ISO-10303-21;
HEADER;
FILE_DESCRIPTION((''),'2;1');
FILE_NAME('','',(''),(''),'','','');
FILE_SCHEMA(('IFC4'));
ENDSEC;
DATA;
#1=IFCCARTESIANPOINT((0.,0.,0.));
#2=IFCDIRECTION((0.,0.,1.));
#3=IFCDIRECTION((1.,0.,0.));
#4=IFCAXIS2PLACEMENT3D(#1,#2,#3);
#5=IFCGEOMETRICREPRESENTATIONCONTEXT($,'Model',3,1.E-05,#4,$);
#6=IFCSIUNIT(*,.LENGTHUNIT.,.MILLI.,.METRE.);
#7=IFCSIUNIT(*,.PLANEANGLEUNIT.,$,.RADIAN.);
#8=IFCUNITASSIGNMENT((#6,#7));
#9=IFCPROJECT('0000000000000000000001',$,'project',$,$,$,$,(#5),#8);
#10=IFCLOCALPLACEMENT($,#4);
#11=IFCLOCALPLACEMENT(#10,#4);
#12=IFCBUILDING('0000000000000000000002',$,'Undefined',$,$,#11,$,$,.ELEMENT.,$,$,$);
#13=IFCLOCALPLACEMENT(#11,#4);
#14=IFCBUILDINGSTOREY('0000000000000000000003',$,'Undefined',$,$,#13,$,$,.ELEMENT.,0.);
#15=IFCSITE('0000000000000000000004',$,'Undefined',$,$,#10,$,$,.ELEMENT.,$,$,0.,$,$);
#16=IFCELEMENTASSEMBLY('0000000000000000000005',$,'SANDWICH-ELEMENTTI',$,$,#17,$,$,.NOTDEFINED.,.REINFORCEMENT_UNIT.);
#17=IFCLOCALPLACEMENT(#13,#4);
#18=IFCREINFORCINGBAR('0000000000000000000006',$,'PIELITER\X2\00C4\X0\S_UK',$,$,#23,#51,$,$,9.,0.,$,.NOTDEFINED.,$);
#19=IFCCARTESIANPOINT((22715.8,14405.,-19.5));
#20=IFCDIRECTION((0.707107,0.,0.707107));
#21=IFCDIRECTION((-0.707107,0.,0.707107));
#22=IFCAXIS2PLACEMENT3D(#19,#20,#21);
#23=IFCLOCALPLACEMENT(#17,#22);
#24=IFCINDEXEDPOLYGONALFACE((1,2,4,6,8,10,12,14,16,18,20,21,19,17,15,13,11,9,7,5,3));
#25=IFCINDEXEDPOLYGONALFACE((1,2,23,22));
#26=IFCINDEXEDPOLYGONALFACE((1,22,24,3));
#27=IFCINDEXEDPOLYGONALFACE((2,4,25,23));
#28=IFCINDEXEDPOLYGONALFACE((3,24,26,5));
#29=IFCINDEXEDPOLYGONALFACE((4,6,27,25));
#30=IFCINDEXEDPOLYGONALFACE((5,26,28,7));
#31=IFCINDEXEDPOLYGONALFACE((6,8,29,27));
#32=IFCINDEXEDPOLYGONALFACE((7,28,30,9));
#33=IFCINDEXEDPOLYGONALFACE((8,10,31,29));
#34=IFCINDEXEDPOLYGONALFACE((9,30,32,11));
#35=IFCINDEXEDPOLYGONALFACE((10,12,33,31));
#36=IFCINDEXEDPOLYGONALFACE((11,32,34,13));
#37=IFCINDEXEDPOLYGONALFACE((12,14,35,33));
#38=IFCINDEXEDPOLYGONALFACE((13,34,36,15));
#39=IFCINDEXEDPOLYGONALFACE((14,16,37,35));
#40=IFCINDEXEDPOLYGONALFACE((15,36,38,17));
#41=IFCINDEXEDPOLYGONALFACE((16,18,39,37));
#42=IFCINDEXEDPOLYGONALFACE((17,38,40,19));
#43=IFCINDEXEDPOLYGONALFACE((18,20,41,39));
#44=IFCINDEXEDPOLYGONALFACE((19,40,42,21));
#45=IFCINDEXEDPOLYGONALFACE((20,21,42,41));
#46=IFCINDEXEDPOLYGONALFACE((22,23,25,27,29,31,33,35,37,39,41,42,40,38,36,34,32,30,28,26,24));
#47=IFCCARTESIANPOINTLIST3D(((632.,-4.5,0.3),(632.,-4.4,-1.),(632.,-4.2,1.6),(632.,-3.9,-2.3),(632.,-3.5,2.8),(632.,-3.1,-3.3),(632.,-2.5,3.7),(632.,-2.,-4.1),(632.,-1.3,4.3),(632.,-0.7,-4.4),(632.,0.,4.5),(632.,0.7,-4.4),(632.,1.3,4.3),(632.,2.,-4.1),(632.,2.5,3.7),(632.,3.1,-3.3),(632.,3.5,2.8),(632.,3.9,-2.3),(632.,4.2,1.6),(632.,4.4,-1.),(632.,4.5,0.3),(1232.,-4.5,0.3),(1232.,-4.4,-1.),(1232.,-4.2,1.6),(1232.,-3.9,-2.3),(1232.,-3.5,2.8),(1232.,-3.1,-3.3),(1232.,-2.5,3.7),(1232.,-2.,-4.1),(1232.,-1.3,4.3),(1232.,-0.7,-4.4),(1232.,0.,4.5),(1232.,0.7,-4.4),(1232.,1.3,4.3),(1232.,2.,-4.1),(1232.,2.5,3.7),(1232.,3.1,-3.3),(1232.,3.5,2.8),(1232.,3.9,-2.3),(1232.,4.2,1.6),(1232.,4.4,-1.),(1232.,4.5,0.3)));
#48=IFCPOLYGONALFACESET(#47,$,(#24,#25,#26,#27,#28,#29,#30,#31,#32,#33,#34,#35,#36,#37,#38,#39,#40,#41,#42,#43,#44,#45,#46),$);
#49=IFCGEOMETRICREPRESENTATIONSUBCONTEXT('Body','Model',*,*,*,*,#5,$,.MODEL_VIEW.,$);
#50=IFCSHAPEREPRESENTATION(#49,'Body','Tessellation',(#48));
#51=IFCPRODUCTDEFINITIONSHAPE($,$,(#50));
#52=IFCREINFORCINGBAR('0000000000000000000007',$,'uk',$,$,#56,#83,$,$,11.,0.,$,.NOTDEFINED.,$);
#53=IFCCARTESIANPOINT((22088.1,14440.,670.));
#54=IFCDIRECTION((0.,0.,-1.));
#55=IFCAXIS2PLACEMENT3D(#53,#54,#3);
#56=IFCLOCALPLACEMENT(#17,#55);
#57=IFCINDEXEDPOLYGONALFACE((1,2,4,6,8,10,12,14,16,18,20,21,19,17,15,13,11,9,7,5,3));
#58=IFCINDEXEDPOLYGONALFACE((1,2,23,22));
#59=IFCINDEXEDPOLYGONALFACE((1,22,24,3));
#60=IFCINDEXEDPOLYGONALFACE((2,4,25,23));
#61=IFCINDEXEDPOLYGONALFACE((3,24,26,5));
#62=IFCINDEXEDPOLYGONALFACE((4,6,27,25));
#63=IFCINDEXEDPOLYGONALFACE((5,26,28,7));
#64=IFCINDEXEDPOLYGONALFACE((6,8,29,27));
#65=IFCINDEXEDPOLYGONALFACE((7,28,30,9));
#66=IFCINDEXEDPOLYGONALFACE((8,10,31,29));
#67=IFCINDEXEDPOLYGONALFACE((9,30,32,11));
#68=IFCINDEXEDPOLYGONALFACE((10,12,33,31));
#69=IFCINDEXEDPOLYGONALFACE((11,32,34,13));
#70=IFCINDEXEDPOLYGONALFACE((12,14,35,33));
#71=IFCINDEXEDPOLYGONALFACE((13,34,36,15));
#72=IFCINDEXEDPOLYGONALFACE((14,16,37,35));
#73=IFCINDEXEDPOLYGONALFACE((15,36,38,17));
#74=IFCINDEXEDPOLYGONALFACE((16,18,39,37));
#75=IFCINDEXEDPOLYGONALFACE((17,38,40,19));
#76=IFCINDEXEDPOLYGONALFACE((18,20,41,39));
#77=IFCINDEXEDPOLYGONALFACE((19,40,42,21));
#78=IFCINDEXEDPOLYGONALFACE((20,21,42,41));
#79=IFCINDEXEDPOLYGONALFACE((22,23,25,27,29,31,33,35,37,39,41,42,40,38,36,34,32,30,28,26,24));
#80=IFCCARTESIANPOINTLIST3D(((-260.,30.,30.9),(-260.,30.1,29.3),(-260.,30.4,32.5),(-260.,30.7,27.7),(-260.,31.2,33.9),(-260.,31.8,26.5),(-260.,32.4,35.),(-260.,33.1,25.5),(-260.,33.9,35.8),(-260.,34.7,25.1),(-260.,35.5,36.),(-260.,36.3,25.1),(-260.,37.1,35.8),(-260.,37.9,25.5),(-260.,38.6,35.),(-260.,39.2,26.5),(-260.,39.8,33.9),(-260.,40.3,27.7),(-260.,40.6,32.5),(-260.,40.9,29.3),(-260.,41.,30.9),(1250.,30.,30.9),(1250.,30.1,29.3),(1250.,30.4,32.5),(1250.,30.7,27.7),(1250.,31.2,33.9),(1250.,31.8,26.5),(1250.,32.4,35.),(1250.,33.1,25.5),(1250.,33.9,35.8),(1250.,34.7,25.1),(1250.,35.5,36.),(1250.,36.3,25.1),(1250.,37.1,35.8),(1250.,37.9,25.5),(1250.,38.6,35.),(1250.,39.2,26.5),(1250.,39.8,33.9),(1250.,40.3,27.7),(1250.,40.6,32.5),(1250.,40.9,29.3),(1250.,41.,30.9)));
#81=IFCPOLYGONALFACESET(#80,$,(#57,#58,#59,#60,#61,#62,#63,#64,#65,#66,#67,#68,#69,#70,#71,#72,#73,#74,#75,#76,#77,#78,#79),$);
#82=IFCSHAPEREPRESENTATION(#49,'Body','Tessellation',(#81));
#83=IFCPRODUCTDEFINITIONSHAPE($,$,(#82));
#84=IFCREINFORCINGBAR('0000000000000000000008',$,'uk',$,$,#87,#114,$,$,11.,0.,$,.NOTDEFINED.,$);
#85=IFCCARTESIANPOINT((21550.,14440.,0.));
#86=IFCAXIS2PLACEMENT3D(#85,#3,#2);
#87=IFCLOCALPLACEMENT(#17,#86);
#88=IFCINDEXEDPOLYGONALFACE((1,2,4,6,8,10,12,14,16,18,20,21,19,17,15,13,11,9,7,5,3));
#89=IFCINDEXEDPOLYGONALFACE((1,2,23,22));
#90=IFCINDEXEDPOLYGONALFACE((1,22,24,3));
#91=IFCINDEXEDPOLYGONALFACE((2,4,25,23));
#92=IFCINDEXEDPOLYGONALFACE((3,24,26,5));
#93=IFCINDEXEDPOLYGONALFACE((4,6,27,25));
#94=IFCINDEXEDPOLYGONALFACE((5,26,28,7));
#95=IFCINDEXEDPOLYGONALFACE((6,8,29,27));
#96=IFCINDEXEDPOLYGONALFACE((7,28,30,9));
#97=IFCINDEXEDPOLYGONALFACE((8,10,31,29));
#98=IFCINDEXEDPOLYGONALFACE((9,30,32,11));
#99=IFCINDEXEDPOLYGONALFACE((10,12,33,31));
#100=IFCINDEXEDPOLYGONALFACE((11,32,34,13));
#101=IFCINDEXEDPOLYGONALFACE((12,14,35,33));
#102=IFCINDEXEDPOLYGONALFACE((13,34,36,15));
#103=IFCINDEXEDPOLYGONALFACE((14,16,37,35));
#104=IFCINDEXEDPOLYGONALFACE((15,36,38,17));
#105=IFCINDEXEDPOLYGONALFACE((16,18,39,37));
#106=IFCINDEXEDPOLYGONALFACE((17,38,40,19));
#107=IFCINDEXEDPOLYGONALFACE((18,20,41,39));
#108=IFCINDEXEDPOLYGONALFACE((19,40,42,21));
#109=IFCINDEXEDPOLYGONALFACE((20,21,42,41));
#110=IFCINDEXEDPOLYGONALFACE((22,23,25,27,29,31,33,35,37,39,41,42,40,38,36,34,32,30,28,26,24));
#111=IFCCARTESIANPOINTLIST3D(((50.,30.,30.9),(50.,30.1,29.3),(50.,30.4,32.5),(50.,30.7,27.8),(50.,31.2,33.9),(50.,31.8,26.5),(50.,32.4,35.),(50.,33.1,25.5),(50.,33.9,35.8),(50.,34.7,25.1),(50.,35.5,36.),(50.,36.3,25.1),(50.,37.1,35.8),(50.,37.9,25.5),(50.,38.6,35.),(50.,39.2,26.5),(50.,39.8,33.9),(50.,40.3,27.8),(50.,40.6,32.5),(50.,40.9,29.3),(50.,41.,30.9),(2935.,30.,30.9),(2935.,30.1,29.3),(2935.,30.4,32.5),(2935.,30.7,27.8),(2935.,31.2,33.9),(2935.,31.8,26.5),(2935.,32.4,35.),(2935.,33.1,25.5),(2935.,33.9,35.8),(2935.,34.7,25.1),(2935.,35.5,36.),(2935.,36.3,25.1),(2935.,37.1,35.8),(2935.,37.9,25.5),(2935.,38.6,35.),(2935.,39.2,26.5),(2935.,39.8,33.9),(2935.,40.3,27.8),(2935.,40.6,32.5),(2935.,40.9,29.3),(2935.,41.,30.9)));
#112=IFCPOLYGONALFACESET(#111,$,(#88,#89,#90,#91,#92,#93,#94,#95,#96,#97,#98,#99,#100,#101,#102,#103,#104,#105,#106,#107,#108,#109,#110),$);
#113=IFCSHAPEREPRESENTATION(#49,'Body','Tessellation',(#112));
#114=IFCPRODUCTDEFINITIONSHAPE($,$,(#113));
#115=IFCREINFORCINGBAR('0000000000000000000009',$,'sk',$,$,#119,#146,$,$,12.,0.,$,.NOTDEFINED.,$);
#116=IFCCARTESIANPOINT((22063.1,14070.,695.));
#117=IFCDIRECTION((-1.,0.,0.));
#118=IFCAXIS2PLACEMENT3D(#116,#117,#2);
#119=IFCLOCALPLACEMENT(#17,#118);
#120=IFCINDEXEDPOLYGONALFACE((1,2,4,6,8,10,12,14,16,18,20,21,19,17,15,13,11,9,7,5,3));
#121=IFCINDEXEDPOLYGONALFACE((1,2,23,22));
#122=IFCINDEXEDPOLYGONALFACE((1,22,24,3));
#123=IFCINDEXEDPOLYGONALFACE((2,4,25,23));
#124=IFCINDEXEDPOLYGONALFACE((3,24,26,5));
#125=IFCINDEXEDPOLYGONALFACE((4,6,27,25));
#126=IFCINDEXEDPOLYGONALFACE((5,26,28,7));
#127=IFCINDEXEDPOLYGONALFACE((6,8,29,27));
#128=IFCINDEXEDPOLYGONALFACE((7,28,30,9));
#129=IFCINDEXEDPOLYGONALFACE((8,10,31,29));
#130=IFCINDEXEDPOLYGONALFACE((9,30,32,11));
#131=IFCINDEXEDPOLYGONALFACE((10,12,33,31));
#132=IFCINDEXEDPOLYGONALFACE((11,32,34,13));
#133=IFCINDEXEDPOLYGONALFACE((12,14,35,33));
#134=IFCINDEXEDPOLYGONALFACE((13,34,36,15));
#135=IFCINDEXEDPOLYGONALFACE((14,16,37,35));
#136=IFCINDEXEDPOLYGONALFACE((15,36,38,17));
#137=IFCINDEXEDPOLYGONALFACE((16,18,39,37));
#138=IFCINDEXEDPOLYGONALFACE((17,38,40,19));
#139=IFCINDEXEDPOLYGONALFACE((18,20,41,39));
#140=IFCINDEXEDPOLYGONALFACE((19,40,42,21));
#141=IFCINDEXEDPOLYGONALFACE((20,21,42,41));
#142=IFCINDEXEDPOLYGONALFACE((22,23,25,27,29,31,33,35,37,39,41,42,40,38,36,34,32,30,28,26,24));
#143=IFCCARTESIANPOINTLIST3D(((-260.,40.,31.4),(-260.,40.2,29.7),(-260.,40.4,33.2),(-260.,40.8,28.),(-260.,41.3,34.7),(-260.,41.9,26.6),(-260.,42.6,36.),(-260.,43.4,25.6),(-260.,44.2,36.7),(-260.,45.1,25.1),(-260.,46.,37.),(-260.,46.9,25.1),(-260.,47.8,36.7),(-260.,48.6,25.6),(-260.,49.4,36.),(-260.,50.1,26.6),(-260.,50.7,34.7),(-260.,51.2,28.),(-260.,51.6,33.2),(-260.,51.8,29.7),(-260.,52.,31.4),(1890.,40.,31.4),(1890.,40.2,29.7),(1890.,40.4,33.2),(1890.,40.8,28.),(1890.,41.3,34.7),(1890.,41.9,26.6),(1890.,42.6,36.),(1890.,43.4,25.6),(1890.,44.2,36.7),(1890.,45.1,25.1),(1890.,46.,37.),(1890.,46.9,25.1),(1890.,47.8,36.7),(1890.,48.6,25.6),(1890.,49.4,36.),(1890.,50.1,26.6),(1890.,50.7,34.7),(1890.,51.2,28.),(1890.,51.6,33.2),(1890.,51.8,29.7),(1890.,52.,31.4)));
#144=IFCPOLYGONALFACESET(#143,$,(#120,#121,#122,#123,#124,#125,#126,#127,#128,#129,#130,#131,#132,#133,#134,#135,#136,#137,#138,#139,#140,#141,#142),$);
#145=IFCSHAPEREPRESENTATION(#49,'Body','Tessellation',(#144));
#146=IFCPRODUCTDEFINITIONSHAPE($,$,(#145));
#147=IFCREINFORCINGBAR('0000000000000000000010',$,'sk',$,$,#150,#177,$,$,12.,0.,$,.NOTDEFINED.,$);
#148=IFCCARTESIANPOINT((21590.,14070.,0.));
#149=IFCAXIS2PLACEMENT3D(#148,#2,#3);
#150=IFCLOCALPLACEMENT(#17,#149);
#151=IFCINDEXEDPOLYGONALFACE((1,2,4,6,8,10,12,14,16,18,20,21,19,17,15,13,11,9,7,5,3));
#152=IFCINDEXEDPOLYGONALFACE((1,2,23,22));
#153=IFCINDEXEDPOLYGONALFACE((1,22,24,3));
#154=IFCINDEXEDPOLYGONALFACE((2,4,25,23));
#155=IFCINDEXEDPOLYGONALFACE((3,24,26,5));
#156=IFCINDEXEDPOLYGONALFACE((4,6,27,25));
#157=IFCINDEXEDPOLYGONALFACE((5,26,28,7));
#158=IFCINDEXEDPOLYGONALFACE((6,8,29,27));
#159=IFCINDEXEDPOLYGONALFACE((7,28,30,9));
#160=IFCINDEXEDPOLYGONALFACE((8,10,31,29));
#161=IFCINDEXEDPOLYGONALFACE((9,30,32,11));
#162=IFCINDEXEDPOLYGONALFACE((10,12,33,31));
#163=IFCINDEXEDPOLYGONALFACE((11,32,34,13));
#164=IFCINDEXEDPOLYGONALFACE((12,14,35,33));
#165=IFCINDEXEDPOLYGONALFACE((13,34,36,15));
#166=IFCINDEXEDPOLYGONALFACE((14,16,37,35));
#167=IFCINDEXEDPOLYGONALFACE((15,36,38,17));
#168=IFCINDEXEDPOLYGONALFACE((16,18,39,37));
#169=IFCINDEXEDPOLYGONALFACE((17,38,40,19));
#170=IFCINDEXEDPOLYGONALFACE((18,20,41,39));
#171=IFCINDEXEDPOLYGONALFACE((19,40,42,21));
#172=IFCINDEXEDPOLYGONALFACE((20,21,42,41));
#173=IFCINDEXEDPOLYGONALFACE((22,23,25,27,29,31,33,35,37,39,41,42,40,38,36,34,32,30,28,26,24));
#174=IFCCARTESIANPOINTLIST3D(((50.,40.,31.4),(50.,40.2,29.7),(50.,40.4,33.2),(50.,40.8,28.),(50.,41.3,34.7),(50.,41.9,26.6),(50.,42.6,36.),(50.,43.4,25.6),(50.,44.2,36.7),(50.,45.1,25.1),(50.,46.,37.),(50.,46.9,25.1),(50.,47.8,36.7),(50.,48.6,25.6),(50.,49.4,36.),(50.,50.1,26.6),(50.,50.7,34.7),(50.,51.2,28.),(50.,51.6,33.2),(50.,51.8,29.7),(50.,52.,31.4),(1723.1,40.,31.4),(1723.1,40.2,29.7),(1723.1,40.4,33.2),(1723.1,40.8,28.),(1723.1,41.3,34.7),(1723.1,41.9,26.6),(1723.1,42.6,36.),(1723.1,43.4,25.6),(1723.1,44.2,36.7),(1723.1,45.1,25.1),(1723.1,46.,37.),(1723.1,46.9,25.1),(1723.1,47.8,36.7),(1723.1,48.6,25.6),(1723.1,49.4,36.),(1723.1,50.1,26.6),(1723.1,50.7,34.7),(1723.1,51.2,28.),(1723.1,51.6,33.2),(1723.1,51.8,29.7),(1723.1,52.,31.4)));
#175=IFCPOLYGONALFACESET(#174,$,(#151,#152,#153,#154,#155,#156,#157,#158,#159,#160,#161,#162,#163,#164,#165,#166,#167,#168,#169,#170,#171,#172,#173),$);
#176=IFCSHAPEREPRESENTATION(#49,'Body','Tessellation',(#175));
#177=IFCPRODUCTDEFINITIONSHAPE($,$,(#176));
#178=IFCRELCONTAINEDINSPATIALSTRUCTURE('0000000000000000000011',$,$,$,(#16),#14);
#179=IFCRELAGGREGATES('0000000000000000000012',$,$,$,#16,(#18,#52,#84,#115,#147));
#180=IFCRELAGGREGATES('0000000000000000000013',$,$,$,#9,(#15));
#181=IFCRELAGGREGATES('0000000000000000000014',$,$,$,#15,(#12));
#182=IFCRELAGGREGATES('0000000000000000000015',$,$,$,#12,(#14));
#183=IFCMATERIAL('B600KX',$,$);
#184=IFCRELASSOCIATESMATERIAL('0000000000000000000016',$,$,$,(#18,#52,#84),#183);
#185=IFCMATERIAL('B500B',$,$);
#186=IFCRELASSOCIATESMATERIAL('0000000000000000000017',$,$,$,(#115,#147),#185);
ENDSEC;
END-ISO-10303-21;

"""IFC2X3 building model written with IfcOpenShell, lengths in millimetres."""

from ifc_helpers import new_model, entity, si_unit, frame, origin_with_axes, place, context, subcontext, project, spatial, source, transform, mapped, material, element, aggregate, save


model = new_model("IFC2X3")

# Units and contexts
model_context = context("Model", 3, precision=1e-05, world=origin_with_axes())
body_context = subcontext(model_context, "Body", "Model", "MODEL_VIEW")
ifc_project = project(units=[si_unit("LENGTHUNIT", "METRE", prefix="MILLI"), si_unit("PLANEANGLEUNIT", "RADIAN")], contexts=[model_context])

# Site, building, storey
site_placement = place(None, origin_with_axes())
site = spatial("IfcSite", under=ifc_project, at=site_placement, Name="Undefined", CompositionType="ELEMENT", RefElevation=0.0)
building_placement = place(site_placement, origin_with_axes())
building = spatial("IfcBuilding", under=site, at=building_placement, Name="Undefined", CompositionType="ELEMENT")
storey_placement = place(building_placement, origin_with_axes())
storey = spatial("IfcBuildingStorey", under=building, at=storey_placement, Name="Undefined", CompositionType="ELEMENT", Elevation=0.0)

# Element assembly
assembly_1_placement = place(storey_placement, origin_with_axes())
assembly_1 = element("IfcElementAssembly", 1, at=assembly_1_placement, inside=storey, Name="SANDWICH-ELEMENTTI", AssemblyPlace="NOTDEFINED", PredefinedType="REINFORCEMENT_UNIT")

# Reinforcing bars
ifc_material_1 = material(Name="B600KX")
shared_shape_1 = source(origin_with_axes(), body_context, "Body", "AdvancedSweptSolid", [
    entity("IfcSweptDiskSolid", entity("IfcTrimmedCurve", entity("IfcLine", entity("IfcCartesianPoint", [0.0, 0.0, 0.0]), entity("IfcVector", entity("IfcDirection", [1.0, 0.0, 0.0]), 1.0)), [entity("IfcParameterValue", 0.0)], [entity("IfcParameterValue", 600.0)], True, "PARAMETER"), 4.5, None, 0.0, 600.0),
])
reinforcing_bar_1_placement = place(assembly_1_placement, frame((22715.8, 14405.0, -19.5), z_axis=(0.707107, 0.0, 0.707107), x_axis=(-0.707107, 0.0, 0.707107)))
reinforcing_bar_1 = element("IfcReinforcingBar", 2, at=reinforcing_bar_1_placement, material=ifc_material_1, Name="PIELITERÄS_UK", BarRole="NOTDEFINED", CrossSectionArea=0.0, NominalDiameter=9.0, context=body_context, shape_type="MappedRepresentation", body=[
    mapped(shared_shape_1, transform((632.0, 0.0, 0.0))),
])
shared_shape_2 = source(origin_with_axes(), body_context, "Body", "AdvancedSweptSolid", [
    entity("IfcSweptDiskSolid", entity("IfcTrimmedCurve", entity("IfcLine", entity("IfcCartesianPoint", [0.0, 0.0, 0.0]), entity("IfcVector", entity("IfcDirection", [1.0, 0.0, 0.0]), 1.0)), [entity("IfcParameterValue", 0.0)], [entity("IfcParameterValue", 1510.0002)], True, "PARAMETER"), 5.5, None, 0.0, 1510.0),
])
reinforcing_bar_2_placement = place(assembly_1_placement, frame((22088.1, 14440.0, 670.0), z_axis=(0.0, 0.0, -1.0), x_axis=(1.0, 0.0, 0.0)))
reinforcing_bar_2 = element("IfcReinforcingBar", 3, at=reinforcing_bar_2_placement, material=ifc_material_1, Name="uk", BarRole="NOTDEFINED", CrossSectionArea=0.0, NominalDiameter=11.0, context=body_context, shape_type="MappedRepresentation", body=[
    mapped(shared_shape_2, transform((-260.0, 35.5, 30.5))),
])
shared_shape_3 = source(origin_with_axes(), body_context, "Body", "AdvancedSweptSolid", [
    entity("IfcSweptDiskSolid", entity("IfcTrimmedCurve", entity("IfcLine", entity("IfcCartesianPoint", [0.0, 0.0, 0.0]), entity("IfcVector", entity("IfcDirection", [1.0, 0.0, 0.0]), 1.0)), [entity("IfcParameterValue", 0.0)], [entity("IfcParameterValue", 2885.0002)], True, "PARAMETER"), 5.5, None, 0.0, 2885.0),
])
reinforcing_bar_3_placement = place(assembly_1_placement, frame((21550.0, 14440.0, 0.0), z_axis=(1.0, 0.0, 0.0), x_axis=(0.0, 0.0, 1.0)))
reinforcing_bar_3 = element("IfcReinforcingBar", 4, at=reinforcing_bar_3_placement, material=ifc_material_1, Name="uk", BarRole="NOTDEFINED", CrossSectionArea=0.0, NominalDiameter=11.0, context=body_context, shape_type="MappedRepresentation", body=[
    mapped(shared_shape_3, transform((50.0, 35.5, 30.5))),
])
ifc_material_2 = material(Name="B500B")
shared_shape_4 = source(origin_with_axes(), body_context, "Body", "AdvancedSweptSolid", [
    entity("IfcSweptDiskSolid", entity("IfcTrimmedCurve", entity("IfcLine", entity("IfcCartesianPoint", [0.0, 0.0, 0.0]), entity("IfcVector", entity("IfcDirection", [1.0, 0.0, 0.0]), 1.0)), [entity("IfcParameterValue", 0.0)], [entity("IfcParameterValue", 2149.9999)], True, "PARAMETER"), 6.0, None, 0.0, 2150.0),
])
reinforcing_bar_4_placement = place(assembly_1_placement, frame((22063.1, 14070.0, 695.0), z_axis=(-1.0, 0.0, 0.0), x_axis=(0.0, 0.0, 1.0)))
reinforcing_bar_4 = element("IfcReinforcingBar", 5, at=reinforcing_bar_4_placement, material=ifc_material_2, Name="sk", BarRole="NOTDEFINED", CrossSectionArea=0.0, NominalDiameter=12.0, context=body_context, shape_type="MappedRepresentation", body=[
    mapped(shared_shape_4, transform((-260.0, 46.0, 31.0))),
])
shared_shape_5 = source(origin_with_axes(), body_context, "Body", "AdvancedSweptSolid", [
    entity("IfcSweptDiskSolid", entity("IfcTrimmedCurve", entity("IfcLine", entity("IfcCartesianPoint", [0.0, 0.0, 0.0]), entity("IfcVector", entity("IfcDirection", [1.0, 0.0, 0.0]), 1.0)), [entity("IfcParameterValue", 0.0)], [entity("IfcParameterValue", 1673.1222)], True, "PARAMETER"), 6.0, None, 0.0, 1673.1),
])
reinforcing_bar_5_placement = place(assembly_1_placement, frame((21590.0, 14070.0, 0.0), z_axis=(0.0, 0.0, 1.0), x_axis=(1.0, 0.0, 0.0)))
reinforcing_bar_5 = element("IfcReinforcingBar", 6, at=reinforcing_bar_5_placement, material=ifc_material_2, Name="sk", BarRole="NOTDEFINED", CrossSectionArea=0.0, NominalDiameter=12.0, context=body_context, shape_type="MappedRepresentation", body=[
    mapped(shared_shape_5, transform((50.0, 46.0, 31.0))),
])
aggregate(assembly_1, [reinforcing_bar_1, reinforcing_bar_2, reinforcing_bar_3, reinforcing_bar_4, reinforcing_bar_5])

save(model, "model.ifc")
